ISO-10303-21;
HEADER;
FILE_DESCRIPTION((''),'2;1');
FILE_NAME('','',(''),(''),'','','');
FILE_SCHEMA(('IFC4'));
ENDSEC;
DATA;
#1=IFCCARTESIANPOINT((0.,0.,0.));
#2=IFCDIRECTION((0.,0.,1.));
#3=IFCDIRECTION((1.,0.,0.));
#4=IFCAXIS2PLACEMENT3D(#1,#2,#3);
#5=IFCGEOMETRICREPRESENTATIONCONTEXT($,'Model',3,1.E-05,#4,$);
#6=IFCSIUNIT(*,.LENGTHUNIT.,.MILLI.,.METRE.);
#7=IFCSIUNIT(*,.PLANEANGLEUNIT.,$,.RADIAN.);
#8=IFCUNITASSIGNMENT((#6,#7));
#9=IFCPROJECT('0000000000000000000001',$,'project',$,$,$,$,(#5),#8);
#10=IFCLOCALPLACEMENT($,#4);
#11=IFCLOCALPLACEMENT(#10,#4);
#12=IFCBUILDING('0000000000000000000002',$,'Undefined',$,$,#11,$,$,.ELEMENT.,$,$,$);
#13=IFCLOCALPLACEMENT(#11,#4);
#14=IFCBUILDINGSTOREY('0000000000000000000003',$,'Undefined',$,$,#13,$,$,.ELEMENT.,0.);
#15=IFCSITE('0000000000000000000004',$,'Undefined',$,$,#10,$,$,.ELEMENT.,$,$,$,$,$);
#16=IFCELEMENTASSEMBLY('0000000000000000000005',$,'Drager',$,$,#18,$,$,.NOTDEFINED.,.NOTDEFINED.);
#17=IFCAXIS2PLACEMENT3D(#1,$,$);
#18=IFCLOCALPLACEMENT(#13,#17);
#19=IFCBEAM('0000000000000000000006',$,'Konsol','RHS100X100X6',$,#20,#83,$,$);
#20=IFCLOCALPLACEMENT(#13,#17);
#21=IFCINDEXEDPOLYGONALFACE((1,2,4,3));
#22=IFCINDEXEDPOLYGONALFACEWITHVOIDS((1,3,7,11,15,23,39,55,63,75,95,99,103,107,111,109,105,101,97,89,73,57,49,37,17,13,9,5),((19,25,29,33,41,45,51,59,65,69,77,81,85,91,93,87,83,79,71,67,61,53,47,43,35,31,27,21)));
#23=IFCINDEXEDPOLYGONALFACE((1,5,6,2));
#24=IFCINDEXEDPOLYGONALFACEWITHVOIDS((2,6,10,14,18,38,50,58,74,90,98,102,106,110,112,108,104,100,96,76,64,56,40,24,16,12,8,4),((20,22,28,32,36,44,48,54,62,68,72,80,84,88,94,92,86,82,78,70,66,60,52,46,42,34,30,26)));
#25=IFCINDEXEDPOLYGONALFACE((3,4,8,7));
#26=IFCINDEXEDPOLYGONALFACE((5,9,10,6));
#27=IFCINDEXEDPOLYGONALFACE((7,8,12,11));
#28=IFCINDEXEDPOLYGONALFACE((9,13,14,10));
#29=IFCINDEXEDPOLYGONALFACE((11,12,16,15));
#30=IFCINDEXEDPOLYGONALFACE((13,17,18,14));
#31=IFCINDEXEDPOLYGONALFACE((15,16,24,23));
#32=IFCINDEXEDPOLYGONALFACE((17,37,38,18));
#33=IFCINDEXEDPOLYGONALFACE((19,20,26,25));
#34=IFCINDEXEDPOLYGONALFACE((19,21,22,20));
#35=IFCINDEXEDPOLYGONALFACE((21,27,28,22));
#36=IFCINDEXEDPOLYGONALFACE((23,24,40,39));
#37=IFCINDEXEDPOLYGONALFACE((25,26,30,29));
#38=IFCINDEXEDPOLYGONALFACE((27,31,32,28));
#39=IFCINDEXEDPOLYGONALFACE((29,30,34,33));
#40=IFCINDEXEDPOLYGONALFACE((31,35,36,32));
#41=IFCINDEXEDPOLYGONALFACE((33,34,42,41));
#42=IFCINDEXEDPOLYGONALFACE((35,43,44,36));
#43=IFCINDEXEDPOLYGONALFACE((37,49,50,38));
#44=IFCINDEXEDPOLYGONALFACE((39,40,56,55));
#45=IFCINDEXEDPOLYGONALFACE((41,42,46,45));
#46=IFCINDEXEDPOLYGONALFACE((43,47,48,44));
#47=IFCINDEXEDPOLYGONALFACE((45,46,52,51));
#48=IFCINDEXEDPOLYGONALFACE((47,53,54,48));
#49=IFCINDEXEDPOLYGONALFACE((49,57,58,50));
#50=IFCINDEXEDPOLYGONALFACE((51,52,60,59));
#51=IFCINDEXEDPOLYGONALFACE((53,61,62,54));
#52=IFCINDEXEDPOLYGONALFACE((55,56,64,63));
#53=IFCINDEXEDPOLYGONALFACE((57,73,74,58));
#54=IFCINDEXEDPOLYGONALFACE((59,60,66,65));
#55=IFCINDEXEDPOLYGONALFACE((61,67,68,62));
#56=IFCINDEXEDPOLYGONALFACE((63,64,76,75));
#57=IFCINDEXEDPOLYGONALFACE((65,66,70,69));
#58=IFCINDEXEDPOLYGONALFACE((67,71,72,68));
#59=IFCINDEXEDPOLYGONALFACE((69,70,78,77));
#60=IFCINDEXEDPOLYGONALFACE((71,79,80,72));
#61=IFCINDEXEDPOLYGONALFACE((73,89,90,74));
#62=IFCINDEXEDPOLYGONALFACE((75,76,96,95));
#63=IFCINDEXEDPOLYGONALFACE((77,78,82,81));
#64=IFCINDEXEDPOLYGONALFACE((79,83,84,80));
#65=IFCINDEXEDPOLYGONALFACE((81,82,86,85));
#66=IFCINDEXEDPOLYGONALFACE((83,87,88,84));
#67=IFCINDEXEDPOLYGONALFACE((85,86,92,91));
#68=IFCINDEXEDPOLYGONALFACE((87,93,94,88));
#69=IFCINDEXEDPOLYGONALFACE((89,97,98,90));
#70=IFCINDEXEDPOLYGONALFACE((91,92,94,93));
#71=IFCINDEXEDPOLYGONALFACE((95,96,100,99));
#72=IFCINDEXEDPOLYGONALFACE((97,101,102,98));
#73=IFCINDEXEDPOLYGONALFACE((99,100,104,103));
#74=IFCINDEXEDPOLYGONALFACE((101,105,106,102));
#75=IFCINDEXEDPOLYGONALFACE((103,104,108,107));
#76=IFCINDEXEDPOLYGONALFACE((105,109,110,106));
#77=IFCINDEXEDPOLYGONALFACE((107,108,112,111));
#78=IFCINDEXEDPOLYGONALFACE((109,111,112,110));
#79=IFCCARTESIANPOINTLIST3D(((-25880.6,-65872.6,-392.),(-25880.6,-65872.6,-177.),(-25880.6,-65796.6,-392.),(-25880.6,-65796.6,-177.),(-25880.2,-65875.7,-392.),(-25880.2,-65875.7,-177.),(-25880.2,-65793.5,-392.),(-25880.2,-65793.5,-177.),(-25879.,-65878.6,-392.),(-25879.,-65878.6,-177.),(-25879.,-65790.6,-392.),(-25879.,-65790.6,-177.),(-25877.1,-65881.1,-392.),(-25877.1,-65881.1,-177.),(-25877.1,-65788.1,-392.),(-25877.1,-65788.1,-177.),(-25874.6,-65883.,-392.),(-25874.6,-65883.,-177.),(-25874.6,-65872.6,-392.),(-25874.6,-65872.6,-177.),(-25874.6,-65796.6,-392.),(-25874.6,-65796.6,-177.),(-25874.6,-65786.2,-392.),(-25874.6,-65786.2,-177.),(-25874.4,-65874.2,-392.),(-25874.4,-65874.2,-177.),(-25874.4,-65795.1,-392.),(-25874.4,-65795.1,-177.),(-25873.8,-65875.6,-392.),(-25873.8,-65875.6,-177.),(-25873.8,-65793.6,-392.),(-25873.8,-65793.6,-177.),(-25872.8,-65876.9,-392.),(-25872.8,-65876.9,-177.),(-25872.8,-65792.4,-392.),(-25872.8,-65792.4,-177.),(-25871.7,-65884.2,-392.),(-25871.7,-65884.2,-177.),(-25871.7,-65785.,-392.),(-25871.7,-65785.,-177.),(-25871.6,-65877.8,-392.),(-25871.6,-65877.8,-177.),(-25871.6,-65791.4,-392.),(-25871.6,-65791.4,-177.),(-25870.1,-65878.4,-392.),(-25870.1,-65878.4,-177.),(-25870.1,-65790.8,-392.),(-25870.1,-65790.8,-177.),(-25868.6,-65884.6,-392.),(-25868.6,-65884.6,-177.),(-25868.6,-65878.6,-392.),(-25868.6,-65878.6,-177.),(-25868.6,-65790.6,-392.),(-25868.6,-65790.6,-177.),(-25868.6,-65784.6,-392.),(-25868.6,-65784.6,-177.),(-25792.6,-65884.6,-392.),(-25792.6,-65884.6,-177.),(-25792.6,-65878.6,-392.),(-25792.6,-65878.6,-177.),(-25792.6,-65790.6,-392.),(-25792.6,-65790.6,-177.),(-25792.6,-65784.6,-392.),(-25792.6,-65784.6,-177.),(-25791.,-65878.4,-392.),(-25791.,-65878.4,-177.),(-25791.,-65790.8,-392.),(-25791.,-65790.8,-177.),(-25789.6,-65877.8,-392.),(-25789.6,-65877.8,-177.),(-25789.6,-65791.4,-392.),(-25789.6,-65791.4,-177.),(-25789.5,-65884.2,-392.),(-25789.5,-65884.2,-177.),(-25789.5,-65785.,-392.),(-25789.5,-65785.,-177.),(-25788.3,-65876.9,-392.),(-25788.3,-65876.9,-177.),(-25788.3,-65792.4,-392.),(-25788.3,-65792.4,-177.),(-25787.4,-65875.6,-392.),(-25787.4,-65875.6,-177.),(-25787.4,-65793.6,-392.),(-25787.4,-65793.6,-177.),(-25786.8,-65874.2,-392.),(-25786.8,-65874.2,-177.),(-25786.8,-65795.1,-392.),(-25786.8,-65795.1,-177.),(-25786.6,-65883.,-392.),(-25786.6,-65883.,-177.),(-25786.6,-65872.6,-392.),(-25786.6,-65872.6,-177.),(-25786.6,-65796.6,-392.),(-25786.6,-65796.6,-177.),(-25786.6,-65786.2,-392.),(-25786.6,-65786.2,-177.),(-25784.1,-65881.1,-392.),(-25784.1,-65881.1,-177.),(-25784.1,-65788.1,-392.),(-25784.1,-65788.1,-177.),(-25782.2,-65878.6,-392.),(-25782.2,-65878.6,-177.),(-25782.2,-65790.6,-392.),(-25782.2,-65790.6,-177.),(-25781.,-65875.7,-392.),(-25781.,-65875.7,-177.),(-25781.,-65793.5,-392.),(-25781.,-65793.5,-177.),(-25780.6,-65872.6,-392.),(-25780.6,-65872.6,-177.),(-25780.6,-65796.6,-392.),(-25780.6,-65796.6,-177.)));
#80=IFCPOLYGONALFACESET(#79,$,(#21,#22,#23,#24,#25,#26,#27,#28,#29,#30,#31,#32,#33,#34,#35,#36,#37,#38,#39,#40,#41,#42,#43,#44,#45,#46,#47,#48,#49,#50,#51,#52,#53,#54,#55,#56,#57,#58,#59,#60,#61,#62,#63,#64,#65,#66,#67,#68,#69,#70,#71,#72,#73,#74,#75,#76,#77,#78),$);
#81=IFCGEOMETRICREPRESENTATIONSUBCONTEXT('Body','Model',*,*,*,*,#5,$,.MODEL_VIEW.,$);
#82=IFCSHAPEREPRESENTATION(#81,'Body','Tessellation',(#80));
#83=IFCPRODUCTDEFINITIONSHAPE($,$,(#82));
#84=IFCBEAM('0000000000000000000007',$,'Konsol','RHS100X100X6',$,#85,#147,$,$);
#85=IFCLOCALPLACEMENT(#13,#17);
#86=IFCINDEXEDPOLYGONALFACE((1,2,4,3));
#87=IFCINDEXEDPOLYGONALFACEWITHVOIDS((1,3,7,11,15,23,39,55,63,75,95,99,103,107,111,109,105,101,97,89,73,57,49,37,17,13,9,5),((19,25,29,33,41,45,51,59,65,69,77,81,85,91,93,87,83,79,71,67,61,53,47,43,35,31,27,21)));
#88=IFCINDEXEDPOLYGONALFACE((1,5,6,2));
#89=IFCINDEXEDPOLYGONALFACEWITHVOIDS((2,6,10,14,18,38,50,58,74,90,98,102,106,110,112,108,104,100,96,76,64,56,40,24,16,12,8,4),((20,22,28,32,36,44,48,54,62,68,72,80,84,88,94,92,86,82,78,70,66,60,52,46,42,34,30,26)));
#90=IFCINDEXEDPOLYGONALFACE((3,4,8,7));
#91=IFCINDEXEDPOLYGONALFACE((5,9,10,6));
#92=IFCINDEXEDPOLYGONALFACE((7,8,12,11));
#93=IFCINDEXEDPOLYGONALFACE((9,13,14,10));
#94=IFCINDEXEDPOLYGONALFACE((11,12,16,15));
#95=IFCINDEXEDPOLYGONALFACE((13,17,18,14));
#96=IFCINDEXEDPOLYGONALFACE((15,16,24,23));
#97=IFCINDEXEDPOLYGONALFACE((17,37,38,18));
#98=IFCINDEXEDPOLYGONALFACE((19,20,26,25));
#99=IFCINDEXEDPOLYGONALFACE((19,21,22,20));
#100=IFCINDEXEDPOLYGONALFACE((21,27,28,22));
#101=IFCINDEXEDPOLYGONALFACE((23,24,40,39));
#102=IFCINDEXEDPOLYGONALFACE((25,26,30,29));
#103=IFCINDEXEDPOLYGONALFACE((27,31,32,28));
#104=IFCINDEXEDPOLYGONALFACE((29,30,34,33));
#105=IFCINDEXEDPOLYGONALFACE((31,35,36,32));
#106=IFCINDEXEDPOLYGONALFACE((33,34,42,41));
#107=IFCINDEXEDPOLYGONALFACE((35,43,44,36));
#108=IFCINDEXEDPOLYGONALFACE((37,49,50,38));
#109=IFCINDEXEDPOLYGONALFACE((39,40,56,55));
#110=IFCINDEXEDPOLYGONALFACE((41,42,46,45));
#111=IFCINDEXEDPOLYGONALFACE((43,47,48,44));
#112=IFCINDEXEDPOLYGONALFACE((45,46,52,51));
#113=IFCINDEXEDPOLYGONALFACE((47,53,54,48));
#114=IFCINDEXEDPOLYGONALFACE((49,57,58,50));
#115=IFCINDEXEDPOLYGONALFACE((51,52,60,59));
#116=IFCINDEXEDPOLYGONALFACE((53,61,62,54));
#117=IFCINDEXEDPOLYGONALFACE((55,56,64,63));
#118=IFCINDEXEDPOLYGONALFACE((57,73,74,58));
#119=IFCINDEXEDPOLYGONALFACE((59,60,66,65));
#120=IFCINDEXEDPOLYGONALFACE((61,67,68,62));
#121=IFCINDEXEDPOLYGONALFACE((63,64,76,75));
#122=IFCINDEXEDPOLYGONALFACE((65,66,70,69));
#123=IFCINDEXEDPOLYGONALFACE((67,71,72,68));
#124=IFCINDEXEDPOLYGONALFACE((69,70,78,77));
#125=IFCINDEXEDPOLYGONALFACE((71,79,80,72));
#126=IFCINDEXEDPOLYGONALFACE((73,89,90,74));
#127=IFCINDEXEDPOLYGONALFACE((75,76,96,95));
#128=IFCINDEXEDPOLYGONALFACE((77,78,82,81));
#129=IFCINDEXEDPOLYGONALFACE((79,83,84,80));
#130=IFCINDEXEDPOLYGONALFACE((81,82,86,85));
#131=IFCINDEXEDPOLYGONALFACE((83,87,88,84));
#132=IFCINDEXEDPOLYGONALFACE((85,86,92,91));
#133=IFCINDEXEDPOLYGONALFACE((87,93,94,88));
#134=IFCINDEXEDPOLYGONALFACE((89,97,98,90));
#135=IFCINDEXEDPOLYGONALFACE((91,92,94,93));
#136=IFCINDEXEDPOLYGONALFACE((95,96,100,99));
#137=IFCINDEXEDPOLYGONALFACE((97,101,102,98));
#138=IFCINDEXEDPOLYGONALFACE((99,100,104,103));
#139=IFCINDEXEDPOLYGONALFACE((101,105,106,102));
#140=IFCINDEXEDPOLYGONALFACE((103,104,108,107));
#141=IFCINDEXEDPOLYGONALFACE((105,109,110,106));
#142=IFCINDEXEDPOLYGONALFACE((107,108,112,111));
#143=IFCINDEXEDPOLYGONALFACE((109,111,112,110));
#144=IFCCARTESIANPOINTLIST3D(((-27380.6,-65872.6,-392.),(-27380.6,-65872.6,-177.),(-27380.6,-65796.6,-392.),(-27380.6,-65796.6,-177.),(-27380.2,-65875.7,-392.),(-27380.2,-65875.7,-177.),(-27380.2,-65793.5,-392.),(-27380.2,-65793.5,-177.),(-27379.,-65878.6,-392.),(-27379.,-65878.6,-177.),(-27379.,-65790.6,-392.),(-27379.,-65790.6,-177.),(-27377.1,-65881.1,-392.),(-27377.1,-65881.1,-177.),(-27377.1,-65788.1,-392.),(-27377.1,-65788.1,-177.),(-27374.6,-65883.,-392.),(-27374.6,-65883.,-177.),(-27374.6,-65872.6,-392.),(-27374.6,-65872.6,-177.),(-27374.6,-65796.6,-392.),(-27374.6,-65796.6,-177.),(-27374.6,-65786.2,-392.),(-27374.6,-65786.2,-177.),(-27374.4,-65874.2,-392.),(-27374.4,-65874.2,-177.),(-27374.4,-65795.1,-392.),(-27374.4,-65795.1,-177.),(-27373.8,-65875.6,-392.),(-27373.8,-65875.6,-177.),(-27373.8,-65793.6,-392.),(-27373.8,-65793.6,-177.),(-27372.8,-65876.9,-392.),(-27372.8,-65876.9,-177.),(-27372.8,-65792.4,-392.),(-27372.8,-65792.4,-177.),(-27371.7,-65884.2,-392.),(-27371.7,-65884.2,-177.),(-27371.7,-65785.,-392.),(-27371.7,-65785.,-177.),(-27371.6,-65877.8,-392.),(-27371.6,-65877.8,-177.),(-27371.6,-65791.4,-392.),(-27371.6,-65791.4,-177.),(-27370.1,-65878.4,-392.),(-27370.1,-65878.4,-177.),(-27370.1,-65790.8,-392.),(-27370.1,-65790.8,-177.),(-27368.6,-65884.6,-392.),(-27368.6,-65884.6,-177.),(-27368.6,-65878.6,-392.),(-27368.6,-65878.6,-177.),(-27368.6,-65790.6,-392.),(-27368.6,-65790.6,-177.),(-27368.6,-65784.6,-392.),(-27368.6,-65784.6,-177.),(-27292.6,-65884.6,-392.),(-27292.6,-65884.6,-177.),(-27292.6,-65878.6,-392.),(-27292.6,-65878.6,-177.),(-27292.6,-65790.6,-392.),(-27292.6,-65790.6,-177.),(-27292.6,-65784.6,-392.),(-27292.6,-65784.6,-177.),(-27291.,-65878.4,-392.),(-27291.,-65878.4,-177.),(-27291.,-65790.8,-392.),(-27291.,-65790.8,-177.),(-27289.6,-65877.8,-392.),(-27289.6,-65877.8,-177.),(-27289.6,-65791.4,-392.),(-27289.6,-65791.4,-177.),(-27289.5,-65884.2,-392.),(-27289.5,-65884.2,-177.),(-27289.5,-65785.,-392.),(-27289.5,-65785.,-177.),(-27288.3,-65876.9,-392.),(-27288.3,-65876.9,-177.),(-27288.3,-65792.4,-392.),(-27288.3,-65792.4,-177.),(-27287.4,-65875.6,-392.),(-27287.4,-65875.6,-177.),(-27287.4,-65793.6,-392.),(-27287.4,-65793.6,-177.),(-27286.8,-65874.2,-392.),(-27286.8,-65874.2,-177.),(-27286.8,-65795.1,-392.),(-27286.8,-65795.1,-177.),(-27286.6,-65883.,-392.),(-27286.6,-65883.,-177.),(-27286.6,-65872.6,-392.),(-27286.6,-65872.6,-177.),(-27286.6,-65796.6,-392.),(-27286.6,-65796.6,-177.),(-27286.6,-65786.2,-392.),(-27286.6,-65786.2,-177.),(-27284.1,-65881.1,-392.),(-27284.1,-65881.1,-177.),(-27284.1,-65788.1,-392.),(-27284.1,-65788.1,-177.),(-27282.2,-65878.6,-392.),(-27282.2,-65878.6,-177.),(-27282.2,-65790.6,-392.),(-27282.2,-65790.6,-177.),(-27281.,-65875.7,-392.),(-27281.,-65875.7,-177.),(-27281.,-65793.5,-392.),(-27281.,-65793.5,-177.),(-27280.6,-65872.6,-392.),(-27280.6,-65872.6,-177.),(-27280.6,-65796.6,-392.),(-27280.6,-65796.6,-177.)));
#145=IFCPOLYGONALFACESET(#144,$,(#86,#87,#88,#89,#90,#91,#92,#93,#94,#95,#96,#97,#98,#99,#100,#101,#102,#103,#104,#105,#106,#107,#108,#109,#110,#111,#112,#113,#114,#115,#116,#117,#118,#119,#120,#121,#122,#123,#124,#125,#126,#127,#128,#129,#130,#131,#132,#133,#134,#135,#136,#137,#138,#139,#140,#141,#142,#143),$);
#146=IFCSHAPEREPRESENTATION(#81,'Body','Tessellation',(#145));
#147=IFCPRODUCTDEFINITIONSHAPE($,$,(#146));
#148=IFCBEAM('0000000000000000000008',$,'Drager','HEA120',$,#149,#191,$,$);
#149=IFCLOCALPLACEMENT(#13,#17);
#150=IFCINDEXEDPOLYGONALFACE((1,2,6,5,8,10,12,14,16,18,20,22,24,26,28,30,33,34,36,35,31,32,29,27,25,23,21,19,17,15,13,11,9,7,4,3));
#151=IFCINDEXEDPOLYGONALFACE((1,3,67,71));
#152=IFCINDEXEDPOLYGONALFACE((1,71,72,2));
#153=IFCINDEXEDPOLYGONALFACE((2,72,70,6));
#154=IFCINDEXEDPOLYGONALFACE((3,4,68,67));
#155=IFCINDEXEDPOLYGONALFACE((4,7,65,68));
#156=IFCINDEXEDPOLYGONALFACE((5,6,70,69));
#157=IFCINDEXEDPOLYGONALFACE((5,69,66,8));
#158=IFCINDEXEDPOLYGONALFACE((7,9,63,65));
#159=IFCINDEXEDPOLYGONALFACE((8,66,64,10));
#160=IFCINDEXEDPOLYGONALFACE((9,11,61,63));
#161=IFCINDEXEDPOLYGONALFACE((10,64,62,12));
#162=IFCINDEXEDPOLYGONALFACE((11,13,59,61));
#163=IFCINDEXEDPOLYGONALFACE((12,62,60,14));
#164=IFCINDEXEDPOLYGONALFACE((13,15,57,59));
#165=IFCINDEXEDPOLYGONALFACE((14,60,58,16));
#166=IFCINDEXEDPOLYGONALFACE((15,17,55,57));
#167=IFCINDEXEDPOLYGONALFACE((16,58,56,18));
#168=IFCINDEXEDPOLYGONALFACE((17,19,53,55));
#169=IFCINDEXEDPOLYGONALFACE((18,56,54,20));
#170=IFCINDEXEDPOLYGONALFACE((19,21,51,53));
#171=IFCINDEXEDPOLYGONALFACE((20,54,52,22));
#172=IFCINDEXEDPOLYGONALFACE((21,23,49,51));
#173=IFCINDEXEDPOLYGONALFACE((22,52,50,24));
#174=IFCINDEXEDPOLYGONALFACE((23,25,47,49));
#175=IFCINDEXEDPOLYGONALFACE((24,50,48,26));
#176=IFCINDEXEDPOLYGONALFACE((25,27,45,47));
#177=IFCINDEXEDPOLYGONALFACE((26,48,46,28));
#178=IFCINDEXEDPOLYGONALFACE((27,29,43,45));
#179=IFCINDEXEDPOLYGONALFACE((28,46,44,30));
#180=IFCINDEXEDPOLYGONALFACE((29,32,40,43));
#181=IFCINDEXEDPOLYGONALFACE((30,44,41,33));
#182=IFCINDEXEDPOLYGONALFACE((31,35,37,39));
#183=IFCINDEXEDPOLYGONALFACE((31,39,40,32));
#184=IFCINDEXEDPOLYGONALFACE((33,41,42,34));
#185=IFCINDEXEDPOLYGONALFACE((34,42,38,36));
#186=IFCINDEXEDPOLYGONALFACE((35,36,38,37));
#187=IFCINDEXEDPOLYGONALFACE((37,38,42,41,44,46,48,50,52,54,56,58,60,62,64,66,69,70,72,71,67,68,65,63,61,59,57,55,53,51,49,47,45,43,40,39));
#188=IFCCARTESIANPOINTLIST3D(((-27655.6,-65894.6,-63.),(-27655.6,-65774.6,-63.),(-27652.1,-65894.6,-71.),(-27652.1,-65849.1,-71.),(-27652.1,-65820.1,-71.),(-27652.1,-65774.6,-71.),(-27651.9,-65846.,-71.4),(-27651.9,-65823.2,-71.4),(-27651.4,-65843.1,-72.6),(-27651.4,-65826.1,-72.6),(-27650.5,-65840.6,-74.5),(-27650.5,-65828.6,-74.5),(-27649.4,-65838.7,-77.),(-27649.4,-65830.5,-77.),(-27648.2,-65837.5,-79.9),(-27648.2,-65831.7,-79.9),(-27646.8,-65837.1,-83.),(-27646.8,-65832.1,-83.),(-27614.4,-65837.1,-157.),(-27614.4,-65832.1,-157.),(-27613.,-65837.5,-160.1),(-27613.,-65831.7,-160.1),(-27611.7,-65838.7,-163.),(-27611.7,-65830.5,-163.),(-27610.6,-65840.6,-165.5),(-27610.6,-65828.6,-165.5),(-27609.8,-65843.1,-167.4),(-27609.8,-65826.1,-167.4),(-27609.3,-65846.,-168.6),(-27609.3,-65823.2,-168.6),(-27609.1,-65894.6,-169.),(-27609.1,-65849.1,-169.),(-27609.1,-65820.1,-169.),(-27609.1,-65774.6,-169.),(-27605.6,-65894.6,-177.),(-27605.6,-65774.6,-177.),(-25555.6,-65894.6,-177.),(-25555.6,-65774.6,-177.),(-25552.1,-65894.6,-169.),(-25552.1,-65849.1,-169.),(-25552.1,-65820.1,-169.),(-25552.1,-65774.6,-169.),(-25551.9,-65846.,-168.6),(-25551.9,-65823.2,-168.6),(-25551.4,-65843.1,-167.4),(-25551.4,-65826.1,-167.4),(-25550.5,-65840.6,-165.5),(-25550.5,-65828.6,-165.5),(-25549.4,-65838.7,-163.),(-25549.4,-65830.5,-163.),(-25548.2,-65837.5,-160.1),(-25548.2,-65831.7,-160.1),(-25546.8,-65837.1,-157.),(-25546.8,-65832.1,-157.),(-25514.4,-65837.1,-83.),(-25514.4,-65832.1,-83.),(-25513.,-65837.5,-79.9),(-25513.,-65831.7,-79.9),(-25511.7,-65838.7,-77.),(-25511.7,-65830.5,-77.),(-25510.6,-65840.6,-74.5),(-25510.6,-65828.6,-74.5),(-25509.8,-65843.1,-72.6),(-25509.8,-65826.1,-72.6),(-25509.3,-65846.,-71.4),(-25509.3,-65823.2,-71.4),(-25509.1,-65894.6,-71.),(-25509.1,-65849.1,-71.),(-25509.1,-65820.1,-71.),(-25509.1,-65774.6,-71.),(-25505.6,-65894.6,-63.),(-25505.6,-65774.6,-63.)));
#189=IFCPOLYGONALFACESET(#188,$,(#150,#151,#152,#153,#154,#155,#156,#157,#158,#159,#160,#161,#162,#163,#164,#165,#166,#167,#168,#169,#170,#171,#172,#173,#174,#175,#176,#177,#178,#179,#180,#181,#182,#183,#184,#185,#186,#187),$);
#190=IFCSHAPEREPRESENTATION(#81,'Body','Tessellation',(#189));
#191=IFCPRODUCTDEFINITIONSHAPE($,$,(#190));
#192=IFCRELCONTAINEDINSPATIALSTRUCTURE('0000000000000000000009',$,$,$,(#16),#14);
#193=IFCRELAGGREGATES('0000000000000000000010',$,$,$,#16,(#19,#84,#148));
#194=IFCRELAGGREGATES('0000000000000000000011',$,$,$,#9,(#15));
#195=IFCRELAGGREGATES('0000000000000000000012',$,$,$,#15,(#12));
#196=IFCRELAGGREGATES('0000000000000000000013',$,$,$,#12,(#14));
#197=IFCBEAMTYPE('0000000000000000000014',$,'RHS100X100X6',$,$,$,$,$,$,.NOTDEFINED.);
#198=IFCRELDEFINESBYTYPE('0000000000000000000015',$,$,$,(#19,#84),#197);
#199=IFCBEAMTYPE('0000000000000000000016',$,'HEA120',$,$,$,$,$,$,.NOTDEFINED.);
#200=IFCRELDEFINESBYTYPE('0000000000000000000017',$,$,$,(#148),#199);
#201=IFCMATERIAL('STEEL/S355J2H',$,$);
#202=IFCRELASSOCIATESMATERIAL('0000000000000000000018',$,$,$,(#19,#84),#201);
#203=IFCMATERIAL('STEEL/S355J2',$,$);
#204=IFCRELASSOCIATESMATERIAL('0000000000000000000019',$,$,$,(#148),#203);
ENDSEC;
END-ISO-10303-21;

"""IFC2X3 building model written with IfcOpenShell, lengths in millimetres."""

from ifc_helpers import new_model, si_unit, frame, origin_with_axes, origin_2d_with_axis, place, context, subcontext, project, spatial, hollow_rectangle, i_section, extrude, clip, halfspace, material, type_object, element, aggregate, save


model = new_model("IFC2X3")

# Units and contexts
model_context = context("Model", 3, precision=1e-05, world=origin_with_axes())
body_context = subcontext(model_context, "Body", "Model", "MODEL_VIEW")
ifc_project = project(units=[si_unit("LENGTHUNIT", "METRE", prefix="MILLI"), si_unit("PLANEANGLEUNIT", "RADIAN")], contexts=[model_context])

# Site, building, storey
site_placement = place(None, origin_with_axes())
site = spatial("IfcSite", under=ifc_project, at=site_placement, Name="Undefined", CompositionType="ELEMENT")
building_placement = place(site_placement, origin_with_axes())
building = spatial("IfcBuilding", under=site, at=building_placement, Name="Undefined", CompositionType="ELEMENT")
storey_placement = place(building_placement, origin_with_axes())
storey = spatial("IfcBuildingStorey", under=building, at=storey_placement, Name="Undefined", CompositionType="ELEMENT", Elevation=0.0)

# Shared definitions
ifc_material_1 = material(Name="STEEL/S355J2")

# Element assembly, beams
assembly_1_placement = place(storey_placement, origin_with_axes())
assembly_1 = element("IfcElementAssembly", 1, at=assembly_1_placement, inside=storey, Name="Drager", AssemblyPlace="NOTDEFINED", PredefinedType="NOTDEFINED")
ifc_material_2 = material(Name="STEEL/S355J2H")
beam_type_1 = type_object("IfcBeamType", Name="RHS100X100X6", PredefinedType="NOTDEFINED")
beam_1_placement = place(assembly_1_placement, frame((-25830.6, -65834.6, -177.0), z_axis=(1.0, 0.0, 0.0), x_axis=(0.0, 0.0, -1.0)))
beam_1 = element("IfcBeam", 2, at=beam_1_placement, type_object=beam_type_1, material=ifc_material_2, Name="Konsol", Description="RHS100X100X6", context=body_context, shape_type="Clipping", body=[
    clip(extrude(hollow_rectangle(XDim=100.0, YDim=100.0, WallThickness=6.0, InnerFilletRadius=6.0, OuterFilletRadius=12.0, at=origin_2d_with_axis()), frame((223.0, 0.0, 0.0), z_axis=(-1.0, 0.0, 0.0), x_axis=(0.0, -1.0, 0.0)), (0.0, 0.0, 1.0), 223.0), halfspace(frame((215.0, 0.0, -50.0), z_axis=(-1.0, 0.0, 0.0), x_axis=(0.0, 1.0, 0.0)), True)),
])
beam_2_placement = place(assembly_1_placement, frame((-27330.6, -65834.6, -177.0), z_axis=(1.0, 0.0, 0.0), x_axis=(0.0, 0.0, -1.0)))
beam_2 = element("IfcBeam", 3, at=beam_2_placement, type_object=beam_type_1, material=ifc_material_2, Name="Konsol", Description="RHS100X100X6", context=body_context, shape_type="Clipping", body=[
    clip(extrude(hollow_rectangle(XDim=100.0, YDim=100.0, WallThickness=6.0, InnerFilletRadius=6.0, OuterFilletRadius=12.0, at=origin_2d_with_axis()), frame((223.0, 0.0, 0.0), z_axis=(-1.0, 0.0, 0.0), x_axis=(0.0, -1.0, 0.0)), (0.0, 0.0, 1.0), 223.0), halfspace(frame((215.0, 0.0, -50.0), z_axis=(-1.0, 0.0, 0.0), x_axis=(0.0, 1.0, 0.0)), True)),
])
beam_type_2 = type_object("IfcBeamType", Name="HEA120", PredefinedType="NOTDEFINED")
beam_3_placement = place(assembly_1_placement, frame((-25505.6, -65834.6, -120.0), z_axis=(0.0, 0.0, -1.0), x_axis=(-1.0, 0.0, 0.0)))
beam_3 = element("IfcBeam", 4, at=beam_3_placement, type_object=beam_type_2, material=ifc_material_1, Name="Drager", Description="HEA120", context=body_context, shape_type="Clipping", body=[
    clip(clip(extrude(i_section(OverallWidth=120.0, OverallDepth=114.0, WebThickness=5.0, FlangeThickness=8.0, FilletRadius=12.0, at=origin_2d_with_axis()), frame((2150.0, 0.0, 0.0), z_axis=(-1.0, 0.0, 0.0), x_axis=(0.0, -1.0, 0.0)), (0.0, 0.0, 1.0), 2150.0), halfspace(frame((50.0, 60.0, 57.0), z_axis=(-0.915788, 0.0, 0.401661), x_axis=(0.0, -1.0, 0.0)), False)), halfspace(frame((2100.0, 60.0, 57.0), z_axis=(0.915788, 0.0, 0.401661), x_axis=(0.401661, 0.0, -0.915788)), False)),
])

aggregate(assembly_1, [beam_1, beam_2, beam_3])

save(model, "model.ifc")
